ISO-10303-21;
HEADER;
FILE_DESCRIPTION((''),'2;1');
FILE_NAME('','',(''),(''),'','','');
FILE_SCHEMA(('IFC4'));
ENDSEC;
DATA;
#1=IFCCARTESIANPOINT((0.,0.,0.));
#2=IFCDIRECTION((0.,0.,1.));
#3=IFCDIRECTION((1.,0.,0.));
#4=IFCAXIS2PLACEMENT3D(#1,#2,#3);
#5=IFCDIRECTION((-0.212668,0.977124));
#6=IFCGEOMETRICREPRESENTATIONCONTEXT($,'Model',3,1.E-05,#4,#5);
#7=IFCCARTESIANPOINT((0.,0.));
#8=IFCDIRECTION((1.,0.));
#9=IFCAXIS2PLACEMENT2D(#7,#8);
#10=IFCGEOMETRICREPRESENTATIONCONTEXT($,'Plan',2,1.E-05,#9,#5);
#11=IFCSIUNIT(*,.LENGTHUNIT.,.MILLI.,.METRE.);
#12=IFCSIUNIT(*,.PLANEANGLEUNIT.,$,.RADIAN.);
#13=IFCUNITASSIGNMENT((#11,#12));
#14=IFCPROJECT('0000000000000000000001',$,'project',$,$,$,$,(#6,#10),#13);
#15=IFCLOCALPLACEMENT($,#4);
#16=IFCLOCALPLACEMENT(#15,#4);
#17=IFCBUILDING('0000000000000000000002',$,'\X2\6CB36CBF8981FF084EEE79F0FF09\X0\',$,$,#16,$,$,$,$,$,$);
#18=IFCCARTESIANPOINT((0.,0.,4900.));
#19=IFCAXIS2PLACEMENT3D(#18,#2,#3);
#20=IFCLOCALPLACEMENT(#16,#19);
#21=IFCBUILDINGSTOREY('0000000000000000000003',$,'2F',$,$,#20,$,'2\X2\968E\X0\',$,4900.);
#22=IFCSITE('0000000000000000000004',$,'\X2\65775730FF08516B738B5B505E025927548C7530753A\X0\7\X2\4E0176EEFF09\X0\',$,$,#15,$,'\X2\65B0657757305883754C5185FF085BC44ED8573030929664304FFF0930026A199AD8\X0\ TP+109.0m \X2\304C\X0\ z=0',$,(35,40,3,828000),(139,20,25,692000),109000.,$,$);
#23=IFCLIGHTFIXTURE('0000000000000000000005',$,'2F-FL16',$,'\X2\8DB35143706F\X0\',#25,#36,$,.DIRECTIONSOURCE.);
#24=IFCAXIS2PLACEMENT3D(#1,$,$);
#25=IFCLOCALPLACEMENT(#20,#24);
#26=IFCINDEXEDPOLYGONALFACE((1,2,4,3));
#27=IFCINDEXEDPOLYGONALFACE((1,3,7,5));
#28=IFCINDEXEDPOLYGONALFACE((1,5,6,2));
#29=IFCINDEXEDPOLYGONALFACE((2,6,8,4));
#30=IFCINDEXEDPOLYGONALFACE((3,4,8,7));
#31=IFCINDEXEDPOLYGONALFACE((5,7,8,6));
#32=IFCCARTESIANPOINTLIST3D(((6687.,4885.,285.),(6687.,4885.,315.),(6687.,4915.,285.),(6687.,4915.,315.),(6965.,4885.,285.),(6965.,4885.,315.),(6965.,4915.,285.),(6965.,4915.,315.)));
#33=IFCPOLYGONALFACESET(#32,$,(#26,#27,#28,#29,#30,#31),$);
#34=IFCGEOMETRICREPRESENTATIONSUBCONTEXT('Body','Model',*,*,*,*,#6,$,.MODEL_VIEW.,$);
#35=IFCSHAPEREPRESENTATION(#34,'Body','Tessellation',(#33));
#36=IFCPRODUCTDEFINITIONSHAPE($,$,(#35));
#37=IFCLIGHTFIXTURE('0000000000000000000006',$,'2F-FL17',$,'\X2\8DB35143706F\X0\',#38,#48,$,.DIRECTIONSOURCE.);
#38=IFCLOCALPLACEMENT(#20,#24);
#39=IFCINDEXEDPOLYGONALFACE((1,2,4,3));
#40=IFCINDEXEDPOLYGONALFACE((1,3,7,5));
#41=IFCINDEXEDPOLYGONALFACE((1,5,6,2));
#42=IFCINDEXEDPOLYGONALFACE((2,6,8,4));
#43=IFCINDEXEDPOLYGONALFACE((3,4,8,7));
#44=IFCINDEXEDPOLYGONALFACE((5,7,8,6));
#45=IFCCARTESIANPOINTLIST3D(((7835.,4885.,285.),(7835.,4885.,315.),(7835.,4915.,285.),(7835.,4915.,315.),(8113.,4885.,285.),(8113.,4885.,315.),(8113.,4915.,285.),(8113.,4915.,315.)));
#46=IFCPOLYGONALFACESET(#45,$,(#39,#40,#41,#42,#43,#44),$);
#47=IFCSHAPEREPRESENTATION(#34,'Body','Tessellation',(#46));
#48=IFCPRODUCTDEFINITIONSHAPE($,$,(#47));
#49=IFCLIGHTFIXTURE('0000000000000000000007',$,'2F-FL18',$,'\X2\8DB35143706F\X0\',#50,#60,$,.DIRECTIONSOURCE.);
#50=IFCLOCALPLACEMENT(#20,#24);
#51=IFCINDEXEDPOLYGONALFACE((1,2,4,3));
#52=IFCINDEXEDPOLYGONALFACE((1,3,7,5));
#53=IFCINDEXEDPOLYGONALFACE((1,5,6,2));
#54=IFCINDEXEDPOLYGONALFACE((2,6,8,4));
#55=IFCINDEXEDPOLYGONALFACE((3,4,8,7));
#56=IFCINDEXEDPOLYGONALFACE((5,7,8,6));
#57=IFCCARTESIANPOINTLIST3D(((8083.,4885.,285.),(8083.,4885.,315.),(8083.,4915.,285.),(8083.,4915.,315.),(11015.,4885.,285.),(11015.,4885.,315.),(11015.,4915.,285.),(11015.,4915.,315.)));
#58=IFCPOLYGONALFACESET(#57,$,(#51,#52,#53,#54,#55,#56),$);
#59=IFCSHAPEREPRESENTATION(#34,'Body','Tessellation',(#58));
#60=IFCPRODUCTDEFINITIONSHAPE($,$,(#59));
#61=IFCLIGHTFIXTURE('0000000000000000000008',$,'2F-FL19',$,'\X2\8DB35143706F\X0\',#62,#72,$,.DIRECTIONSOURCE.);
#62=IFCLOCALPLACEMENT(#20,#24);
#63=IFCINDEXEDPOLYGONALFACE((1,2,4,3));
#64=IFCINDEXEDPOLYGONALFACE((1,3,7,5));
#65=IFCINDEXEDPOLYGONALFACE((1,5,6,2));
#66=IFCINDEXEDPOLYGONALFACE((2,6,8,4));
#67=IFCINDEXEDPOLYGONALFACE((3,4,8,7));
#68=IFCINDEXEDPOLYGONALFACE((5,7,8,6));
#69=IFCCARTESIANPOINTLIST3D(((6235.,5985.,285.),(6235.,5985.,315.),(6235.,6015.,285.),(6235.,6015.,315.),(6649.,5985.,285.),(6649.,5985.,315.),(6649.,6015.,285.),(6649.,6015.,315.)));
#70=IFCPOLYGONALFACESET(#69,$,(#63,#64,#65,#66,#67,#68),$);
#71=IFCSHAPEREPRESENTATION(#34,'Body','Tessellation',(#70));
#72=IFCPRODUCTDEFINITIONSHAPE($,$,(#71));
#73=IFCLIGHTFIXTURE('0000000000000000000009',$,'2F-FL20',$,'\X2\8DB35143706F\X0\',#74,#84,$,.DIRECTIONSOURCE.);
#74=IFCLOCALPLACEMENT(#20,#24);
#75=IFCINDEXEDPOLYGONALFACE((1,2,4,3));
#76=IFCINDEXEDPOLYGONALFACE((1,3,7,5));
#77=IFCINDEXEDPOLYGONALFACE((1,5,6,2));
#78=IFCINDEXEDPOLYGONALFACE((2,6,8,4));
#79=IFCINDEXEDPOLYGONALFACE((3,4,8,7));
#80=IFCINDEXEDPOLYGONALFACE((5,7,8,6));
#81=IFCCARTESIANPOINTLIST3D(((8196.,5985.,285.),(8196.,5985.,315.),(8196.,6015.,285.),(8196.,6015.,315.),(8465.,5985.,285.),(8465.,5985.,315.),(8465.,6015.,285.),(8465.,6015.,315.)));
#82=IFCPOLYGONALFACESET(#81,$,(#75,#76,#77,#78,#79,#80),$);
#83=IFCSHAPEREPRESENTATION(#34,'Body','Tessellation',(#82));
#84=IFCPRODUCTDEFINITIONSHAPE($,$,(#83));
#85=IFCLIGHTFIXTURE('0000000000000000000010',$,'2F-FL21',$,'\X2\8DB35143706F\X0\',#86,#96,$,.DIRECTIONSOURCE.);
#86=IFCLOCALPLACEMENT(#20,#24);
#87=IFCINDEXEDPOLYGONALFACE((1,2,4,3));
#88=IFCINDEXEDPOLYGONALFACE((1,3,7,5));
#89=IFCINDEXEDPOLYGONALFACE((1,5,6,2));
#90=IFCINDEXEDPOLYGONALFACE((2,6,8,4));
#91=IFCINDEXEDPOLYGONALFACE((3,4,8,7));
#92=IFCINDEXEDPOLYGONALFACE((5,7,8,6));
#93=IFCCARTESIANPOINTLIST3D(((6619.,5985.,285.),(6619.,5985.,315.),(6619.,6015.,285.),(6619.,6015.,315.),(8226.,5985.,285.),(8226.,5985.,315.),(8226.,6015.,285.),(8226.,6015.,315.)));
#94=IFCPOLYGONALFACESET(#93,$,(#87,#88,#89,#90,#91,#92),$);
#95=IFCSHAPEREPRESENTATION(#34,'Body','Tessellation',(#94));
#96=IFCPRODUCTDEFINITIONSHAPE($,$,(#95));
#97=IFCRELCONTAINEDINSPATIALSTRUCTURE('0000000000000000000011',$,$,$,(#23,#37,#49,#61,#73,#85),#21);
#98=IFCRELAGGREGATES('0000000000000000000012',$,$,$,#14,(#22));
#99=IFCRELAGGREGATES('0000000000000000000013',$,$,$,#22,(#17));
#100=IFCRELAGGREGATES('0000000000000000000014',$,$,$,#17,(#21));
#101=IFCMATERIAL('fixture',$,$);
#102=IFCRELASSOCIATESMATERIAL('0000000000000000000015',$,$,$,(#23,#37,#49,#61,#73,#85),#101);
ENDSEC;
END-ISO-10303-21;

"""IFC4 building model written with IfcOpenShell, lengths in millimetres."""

from ifc_helpers import new_model, si_unit, direction, frame, frame_2d, origin_with_axes, origin_2d_with_axis, place, context, subcontext, project, spatial, rectangle, extrude, material, element, save


model = new_model("IFC4")

# Units and contexts
model_context = context("Model", 3, precision=1e-05, world=origin_with_axes(), true_north=direction((-0.212668, 0.977124)))
plan_context = context("Plan", 2, precision=1e-05, world=origin_2d_with_axis(), true_north=direction((-0.212668, 0.977124)))
body_context = subcontext(model_context, "Body", "Model", "MODEL_VIEW")
ifc_project = project(units=[si_unit("LENGTHUNIT", "METRE", prefix="MILLI"), si_unit("PLANEANGLEUNIT", "RADIAN")], contexts=[model_context, plan_context])

# Site, building, storey
site_placement = place(None, origin_with_axes())
site = spatial("IfcSite", under=ifc_project, at=site_placement, Name="敷地（八王子市大和田町7丁目）", LongName="新敷地境界内（寄付地を除く）。標高 TP+109.0m が z=0", RefLatitude=(35, 40, 3, 828000), RefLongitude=(139, 20, 25, 692000), RefElevation=109000.0)
building_placement = place(site_placement, origin_with_axes())
building = spatial("IfcBuilding", under=site, at=building_placement, Name="河沿要（仮称）")
storey_placement = place(building_placement, frame((0.0, 0.0, 4900.0), z_axis=(0.0, 0.0, 1.0), x_axis=(1.0, 0.0, 0.0)))
storey = spatial("IfcBuildingStorey", under=building, at=storey_placement, Name="2F", LongName="2階", Elevation=4900.0)

# Light fixtures
ifc_material = material(Name="fixture")
light_fixture_1_placement = place(storey_placement, origin_with_axes())
element("IfcLightFixture", 1, at=light_fixture_1_placement, inside=storey, material=ifc_material, Name="2F-FL16", ObjectType="足元灯", PredefinedType="DIRECTIONSOURCE", context=body_context, shape_type="SweptSolid", body=[
    extrude(rectangle(XDim=278.0, YDim=30.0, at=frame_2d((6826.0, 4900.0))), frame((0.0, 0.0, 285.0)), (0.0, 0.0, 1.0), 30.0),
])
light_fixture_2_placement = place(storey_placement, origin_with_axes())
element("IfcLightFixture", 2, at=light_fixture_2_placement, inside=storey, material=ifc_material, Name="2F-FL17", ObjectType="足元灯", PredefinedType="DIRECTIONSOURCE", context=body_context, shape_type="SweptSolid", body=[
    extrude(rectangle(XDim=278.0, YDim=30.0, at=frame_2d((7974.0, 4900.0))), frame((0.0, 0.0, 285.0)), (0.0, 0.0, 1.0), 30.0),
])
light_fixture_3_placement = place(storey_placement, origin_with_axes())
element("IfcLightFixture", 3, at=light_fixture_3_placement, inside=storey, material=ifc_material, Name="2F-FL18", ObjectType="足元灯", PredefinedType="DIRECTIONSOURCE", context=body_context, shape_type="SweptSolid", body=[
    extrude(rectangle(XDim=2932.0, YDim=30.0, at=frame_2d((9549.0, 4900.0))), frame((0.0, 0.0, 285.0)), (0.0, 0.0, 1.0), 30.0),
])
light_fixture_4_placement = place(storey_placement, origin_with_axes())
element("IfcLightFixture", 4, at=light_fixture_4_placement, inside=storey, material=ifc_material, Name="2F-FL19", ObjectType="足元灯", PredefinedType="DIRECTIONSOURCE", context=body_context, shape_type="SweptSolid", body=[
    extrude(rectangle(XDim=414.0, YDim=30.0, at=frame_2d((6442.0, 6000.0))), frame((0.0, 0.0, 285.0)), (0.0, 0.0, 1.0), 30.0),
])
light_fixture_5_placement = place(storey_placement, origin_with_axes())
element("IfcLightFixture", 5, at=light_fixture_5_placement, inside=storey, material=ifc_material, Name="2F-FL20", ObjectType="足元灯", PredefinedType="DIRECTIONSOURCE", context=body_context, shape_type="SweptSolid", body=[
    extrude(rectangle(XDim=269.0, YDim=30.0, at=frame_2d((8330.5, 6000.0))), frame((0.0, 0.0, 285.0)), (0.0, 0.0, 1.0), 30.0),
])
light_fixture_6_placement = place(storey_placement, origin_with_axes())
element("IfcLightFixture", 6, at=light_fixture_6_placement, inside=storey, material=ifc_material, Name="2F-FL21", ObjectType="足元灯", PredefinedType="DIRECTIONSOURCE", context=body_context, shape_type="SweptSolid", body=[
    extrude(rectangle(XDim=1607.0, YDim=30.0, at=frame_2d((7422.5, 6000.0))), frame((0.0, 0.0, 285.0)), (0.0, 0.0, 1.0), 30.0),
])

save(model, "model.ifc")
